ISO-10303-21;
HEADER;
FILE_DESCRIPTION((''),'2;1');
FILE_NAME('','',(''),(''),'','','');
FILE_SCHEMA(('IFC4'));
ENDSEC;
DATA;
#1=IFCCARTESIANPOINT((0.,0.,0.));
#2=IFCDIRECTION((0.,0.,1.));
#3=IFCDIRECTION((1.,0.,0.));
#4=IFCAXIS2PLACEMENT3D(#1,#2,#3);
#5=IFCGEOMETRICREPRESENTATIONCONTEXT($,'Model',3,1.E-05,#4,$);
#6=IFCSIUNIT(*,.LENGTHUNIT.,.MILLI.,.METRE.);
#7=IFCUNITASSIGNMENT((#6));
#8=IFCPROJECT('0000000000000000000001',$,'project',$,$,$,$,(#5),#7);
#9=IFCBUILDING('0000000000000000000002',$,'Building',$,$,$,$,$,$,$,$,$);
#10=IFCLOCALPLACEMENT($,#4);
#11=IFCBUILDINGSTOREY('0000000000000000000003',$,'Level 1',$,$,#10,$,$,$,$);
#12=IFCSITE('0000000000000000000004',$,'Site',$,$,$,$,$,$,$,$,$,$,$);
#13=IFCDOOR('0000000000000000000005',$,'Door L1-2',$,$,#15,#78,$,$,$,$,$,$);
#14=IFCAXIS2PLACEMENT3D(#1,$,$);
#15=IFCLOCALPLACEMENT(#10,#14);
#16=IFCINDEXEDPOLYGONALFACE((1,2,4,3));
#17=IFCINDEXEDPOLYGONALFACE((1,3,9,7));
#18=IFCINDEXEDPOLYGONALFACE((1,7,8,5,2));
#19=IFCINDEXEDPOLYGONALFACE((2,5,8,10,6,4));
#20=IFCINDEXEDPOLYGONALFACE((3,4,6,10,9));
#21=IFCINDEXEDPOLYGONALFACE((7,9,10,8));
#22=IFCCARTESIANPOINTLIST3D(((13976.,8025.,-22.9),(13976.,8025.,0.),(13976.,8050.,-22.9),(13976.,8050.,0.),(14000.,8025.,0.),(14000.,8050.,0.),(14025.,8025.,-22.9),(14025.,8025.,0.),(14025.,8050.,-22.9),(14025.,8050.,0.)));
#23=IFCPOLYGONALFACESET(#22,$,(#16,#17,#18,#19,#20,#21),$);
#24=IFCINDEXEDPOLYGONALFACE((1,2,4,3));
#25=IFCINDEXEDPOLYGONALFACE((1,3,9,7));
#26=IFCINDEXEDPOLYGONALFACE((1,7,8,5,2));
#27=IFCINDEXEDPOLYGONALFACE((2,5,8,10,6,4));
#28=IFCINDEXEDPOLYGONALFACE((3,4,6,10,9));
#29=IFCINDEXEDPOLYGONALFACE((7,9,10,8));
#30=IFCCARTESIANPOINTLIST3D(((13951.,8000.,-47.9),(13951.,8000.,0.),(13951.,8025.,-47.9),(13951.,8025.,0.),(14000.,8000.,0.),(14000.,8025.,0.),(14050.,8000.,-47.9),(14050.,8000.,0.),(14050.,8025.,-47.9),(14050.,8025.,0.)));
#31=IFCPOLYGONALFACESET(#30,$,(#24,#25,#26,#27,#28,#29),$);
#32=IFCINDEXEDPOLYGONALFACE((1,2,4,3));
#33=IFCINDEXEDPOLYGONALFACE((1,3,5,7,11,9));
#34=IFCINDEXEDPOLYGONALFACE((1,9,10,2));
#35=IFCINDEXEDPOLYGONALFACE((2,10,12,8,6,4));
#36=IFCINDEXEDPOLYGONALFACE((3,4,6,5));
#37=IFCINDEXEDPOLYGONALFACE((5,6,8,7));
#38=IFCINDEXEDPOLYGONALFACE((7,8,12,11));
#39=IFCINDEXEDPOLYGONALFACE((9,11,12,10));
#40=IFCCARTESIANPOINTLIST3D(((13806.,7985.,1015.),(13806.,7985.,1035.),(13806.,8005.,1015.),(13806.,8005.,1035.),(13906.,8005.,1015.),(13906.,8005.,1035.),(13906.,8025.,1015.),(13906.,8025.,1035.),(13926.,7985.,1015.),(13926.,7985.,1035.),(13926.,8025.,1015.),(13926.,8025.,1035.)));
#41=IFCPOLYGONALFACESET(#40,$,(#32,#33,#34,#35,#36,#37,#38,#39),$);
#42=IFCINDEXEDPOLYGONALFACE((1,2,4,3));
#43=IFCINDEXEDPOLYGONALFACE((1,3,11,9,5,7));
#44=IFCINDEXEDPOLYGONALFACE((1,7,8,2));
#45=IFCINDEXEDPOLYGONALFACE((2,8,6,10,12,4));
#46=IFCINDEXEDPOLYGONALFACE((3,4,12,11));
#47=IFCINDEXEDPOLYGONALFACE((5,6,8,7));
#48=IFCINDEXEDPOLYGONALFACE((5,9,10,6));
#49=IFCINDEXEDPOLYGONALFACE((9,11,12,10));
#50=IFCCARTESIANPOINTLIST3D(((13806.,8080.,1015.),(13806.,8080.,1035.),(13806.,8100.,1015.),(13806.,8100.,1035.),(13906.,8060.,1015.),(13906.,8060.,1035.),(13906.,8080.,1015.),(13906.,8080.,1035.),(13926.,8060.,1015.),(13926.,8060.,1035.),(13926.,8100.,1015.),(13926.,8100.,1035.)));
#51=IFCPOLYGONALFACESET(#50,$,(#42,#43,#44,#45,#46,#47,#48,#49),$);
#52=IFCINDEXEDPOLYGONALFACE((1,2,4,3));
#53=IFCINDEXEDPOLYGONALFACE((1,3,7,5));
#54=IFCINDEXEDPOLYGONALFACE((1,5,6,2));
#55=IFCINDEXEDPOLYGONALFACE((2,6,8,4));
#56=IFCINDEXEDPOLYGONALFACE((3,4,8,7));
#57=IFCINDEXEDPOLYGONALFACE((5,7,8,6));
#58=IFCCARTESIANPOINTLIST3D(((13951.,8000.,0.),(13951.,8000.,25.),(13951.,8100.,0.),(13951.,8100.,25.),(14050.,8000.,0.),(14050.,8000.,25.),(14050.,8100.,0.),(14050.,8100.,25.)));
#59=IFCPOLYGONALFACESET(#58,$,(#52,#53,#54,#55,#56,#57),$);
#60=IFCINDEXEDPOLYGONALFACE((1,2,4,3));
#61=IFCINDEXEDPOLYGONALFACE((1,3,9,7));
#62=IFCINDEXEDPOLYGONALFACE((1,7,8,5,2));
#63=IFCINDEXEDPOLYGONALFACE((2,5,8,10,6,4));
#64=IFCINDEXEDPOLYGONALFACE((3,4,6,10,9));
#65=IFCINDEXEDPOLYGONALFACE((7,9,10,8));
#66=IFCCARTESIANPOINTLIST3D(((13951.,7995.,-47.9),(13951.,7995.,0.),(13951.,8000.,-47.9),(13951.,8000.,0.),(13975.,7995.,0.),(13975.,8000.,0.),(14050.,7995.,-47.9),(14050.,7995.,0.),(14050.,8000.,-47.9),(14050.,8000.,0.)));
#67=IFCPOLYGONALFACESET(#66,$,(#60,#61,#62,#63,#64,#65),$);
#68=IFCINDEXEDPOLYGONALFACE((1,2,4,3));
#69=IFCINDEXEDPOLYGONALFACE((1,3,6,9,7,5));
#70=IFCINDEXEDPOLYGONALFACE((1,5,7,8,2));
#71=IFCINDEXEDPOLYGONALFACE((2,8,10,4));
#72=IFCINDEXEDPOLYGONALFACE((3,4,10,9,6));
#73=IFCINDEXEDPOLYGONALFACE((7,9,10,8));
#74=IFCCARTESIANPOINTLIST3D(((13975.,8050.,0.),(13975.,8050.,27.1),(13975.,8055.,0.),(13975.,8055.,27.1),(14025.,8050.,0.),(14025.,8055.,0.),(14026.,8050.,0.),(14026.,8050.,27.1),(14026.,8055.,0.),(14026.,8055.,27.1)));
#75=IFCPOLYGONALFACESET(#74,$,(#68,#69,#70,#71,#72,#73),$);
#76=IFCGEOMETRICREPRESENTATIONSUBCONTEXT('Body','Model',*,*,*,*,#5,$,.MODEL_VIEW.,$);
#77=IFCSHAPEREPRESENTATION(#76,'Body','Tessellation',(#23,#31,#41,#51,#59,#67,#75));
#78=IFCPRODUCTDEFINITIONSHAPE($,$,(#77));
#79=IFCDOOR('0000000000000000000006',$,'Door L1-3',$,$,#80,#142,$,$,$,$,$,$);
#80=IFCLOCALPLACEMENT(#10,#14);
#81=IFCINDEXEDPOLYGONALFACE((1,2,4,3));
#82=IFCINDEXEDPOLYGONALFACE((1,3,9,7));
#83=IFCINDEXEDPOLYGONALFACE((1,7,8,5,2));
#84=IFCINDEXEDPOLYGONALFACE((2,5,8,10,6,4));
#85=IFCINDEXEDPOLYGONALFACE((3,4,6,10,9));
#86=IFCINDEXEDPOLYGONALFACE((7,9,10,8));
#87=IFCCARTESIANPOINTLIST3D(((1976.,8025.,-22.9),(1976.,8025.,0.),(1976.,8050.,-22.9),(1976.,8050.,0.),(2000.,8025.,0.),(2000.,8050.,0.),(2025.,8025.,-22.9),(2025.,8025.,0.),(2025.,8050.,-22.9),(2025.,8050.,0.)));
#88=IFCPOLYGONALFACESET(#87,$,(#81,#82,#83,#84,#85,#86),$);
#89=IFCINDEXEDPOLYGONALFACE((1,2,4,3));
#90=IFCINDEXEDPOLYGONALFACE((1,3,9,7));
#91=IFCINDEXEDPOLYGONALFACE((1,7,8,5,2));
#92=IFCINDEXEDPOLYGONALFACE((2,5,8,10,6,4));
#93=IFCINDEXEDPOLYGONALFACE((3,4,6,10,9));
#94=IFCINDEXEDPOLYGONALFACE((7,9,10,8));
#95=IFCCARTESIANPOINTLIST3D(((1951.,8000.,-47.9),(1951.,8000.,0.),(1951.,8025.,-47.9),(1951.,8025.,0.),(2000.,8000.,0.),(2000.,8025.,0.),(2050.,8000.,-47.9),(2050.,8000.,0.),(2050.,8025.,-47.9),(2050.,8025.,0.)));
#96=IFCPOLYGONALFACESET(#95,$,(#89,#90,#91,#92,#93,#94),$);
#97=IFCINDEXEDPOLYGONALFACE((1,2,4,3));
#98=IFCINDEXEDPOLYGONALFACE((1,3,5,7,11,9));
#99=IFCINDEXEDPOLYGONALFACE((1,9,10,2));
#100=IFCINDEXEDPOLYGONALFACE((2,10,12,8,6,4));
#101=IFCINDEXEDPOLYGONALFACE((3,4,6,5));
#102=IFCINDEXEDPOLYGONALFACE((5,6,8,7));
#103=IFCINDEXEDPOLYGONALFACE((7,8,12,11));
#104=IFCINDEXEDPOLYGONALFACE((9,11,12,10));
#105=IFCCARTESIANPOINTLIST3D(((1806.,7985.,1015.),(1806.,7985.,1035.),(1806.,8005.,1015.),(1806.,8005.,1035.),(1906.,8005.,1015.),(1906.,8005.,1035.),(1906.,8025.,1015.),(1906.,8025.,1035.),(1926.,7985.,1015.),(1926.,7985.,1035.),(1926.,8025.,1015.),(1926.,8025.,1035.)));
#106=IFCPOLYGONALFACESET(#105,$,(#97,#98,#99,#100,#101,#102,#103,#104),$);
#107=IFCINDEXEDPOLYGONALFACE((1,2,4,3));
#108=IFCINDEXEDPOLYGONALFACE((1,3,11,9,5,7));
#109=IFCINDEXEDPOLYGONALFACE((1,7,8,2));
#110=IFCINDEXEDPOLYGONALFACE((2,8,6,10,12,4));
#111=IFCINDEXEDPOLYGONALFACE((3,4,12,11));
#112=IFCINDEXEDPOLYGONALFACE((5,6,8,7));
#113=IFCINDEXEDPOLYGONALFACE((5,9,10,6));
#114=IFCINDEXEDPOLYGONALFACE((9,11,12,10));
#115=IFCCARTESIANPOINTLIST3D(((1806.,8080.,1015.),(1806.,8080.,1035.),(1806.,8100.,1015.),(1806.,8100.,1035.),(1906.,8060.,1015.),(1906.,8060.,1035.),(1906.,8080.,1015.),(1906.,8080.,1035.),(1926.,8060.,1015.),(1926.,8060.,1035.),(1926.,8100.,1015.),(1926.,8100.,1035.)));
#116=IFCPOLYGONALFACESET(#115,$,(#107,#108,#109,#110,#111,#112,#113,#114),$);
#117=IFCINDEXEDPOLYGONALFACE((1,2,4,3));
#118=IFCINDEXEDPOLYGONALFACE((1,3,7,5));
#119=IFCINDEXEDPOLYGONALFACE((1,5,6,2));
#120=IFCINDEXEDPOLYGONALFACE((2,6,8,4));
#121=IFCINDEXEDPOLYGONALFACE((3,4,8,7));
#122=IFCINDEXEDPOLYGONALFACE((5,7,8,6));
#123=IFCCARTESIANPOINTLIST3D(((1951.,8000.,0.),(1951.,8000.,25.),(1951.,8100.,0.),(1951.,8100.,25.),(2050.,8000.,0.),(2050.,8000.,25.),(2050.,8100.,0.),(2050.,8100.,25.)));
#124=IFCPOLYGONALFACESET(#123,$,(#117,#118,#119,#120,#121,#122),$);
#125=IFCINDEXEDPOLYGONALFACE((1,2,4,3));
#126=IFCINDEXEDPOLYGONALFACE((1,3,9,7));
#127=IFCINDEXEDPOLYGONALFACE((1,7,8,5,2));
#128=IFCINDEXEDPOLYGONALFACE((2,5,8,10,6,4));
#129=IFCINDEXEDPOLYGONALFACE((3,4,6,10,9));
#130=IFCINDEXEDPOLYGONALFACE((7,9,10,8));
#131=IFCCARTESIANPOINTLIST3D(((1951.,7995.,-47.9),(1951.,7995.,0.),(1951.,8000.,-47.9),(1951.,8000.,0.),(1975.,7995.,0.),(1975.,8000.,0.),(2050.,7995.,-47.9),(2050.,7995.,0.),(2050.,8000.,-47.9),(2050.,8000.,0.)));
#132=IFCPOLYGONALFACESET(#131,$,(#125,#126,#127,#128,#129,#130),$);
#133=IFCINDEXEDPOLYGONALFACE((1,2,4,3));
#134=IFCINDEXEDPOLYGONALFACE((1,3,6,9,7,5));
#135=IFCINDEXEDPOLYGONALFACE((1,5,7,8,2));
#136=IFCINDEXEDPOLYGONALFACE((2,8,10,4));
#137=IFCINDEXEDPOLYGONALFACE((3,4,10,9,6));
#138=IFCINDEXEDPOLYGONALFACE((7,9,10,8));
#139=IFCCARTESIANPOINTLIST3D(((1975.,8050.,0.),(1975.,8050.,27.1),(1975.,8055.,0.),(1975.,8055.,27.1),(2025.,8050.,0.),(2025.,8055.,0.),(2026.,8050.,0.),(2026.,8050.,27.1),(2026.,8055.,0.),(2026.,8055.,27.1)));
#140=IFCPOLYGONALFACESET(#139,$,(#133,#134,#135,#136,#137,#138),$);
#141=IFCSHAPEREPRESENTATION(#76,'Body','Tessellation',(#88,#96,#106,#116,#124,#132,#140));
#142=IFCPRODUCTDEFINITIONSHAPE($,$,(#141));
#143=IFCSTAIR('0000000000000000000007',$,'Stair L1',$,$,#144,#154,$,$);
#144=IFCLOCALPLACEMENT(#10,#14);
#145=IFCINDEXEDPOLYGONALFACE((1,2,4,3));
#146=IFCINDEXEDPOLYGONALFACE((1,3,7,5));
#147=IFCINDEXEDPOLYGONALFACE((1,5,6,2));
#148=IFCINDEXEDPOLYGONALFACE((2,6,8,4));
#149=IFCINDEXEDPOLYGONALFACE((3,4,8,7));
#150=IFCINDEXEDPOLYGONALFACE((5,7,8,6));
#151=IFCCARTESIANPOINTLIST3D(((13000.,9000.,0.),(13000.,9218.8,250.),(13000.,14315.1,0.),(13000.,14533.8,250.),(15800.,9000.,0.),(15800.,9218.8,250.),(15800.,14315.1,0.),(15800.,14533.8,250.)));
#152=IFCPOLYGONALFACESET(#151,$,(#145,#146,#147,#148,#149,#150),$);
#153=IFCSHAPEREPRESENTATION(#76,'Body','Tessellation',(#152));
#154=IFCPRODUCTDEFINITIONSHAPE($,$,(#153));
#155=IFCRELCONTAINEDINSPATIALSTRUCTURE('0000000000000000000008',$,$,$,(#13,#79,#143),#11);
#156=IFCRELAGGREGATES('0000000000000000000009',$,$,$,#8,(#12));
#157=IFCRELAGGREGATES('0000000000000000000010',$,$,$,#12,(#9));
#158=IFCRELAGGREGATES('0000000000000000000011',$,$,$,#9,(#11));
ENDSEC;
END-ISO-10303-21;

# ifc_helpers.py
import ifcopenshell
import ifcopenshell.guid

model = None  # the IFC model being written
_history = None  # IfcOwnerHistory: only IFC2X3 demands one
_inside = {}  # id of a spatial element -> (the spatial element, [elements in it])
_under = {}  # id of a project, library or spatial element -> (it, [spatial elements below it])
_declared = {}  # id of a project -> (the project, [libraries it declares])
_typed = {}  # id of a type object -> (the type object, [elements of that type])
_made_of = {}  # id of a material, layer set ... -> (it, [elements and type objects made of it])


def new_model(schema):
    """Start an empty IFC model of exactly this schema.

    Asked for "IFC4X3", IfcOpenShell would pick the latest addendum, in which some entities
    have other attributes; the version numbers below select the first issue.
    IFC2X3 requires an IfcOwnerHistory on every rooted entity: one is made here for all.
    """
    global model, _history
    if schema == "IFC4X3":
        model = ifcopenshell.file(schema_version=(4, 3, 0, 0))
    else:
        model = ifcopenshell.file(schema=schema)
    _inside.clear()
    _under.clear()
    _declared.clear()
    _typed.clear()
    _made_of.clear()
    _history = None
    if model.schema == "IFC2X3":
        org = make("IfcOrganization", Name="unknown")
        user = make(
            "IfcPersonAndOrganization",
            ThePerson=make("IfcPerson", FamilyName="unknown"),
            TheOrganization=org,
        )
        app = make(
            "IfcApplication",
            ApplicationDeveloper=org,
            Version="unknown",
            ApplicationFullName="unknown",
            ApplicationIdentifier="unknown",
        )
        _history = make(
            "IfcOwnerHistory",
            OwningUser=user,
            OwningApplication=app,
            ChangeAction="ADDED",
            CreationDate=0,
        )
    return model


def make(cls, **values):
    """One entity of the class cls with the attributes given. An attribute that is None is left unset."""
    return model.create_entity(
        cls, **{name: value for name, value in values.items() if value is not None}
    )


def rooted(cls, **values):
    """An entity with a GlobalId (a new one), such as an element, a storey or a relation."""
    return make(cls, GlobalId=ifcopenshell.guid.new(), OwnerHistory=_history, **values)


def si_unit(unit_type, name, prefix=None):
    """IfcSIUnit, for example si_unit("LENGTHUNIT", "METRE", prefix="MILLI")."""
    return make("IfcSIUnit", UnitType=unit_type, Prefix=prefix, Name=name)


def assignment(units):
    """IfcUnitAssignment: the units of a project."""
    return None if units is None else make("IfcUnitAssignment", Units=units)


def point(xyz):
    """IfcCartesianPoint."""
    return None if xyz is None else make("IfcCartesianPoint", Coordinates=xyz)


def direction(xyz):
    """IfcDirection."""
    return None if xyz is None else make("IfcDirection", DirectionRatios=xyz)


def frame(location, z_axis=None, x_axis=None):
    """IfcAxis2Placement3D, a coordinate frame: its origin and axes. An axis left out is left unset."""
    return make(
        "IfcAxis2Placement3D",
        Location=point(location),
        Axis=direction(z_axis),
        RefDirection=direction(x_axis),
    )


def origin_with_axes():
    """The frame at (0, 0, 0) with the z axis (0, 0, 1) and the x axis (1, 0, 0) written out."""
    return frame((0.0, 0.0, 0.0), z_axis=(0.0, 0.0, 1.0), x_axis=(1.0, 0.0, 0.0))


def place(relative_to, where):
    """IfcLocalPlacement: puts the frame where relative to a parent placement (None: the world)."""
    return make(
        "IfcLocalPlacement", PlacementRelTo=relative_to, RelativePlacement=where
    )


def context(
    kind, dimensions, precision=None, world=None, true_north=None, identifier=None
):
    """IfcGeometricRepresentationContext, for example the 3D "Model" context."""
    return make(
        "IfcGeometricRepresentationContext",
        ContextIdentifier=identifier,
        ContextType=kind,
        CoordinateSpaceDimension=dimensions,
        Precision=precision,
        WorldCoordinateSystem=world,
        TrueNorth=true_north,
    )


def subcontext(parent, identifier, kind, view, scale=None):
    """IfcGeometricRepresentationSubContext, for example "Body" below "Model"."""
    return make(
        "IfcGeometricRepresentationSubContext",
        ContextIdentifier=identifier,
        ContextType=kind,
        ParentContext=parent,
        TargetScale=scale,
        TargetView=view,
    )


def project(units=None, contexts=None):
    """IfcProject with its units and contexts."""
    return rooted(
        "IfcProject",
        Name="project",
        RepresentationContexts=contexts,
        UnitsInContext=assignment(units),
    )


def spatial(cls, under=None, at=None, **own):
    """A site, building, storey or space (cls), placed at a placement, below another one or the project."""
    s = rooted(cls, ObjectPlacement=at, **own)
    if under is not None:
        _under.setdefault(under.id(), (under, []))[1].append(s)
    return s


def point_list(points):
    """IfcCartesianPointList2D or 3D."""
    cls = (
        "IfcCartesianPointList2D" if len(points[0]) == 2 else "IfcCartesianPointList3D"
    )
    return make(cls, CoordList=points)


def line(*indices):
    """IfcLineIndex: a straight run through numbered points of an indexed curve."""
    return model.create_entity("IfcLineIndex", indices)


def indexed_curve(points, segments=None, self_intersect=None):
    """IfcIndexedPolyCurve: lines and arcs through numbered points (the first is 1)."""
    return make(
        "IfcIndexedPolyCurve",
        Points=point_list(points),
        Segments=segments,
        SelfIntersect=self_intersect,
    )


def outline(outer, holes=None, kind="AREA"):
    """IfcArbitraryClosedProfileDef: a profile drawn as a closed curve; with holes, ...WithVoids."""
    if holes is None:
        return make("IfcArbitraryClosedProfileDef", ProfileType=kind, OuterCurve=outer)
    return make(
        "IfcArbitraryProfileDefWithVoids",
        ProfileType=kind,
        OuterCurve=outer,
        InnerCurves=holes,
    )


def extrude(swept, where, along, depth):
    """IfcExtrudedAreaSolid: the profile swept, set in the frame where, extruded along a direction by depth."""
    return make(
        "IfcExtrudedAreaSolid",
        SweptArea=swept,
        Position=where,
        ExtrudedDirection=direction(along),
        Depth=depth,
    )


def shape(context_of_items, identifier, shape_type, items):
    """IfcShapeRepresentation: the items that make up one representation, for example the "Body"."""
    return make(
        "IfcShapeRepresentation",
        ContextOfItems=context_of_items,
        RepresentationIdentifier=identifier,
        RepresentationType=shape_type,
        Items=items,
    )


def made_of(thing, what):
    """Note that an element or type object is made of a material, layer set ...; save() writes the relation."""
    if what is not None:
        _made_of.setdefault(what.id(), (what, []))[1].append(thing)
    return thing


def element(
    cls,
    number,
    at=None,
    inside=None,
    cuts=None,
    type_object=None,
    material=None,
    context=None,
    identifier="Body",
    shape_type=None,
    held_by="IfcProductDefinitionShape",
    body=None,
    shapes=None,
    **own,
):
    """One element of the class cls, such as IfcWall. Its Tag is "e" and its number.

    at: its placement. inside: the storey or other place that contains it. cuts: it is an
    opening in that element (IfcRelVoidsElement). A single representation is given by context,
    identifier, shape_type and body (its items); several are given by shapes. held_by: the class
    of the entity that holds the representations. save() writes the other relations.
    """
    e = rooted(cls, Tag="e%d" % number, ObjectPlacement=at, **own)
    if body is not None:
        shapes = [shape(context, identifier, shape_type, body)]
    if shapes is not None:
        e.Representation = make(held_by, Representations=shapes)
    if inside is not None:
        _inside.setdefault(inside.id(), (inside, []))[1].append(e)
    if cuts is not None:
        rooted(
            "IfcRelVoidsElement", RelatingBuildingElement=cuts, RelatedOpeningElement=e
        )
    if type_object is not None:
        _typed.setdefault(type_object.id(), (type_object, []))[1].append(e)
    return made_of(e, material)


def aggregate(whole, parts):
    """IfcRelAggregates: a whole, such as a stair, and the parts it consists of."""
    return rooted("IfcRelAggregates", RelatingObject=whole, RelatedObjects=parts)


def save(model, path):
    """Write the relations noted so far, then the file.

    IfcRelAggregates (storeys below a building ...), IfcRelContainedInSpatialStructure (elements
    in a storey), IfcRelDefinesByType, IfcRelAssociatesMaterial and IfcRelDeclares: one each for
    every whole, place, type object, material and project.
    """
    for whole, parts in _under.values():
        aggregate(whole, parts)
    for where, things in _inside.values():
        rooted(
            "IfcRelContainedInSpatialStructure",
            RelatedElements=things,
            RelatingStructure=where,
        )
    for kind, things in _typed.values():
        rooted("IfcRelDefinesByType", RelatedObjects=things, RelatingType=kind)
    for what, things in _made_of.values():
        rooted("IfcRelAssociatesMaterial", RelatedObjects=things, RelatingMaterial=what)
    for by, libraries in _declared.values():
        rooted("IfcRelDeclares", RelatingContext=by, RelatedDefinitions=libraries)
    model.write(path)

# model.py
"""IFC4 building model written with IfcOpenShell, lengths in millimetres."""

from ifc_helpers import new_model, si_unit, frame, origin_with_axes, place, context, subcontext, project, spatial, line, indexed_curve, outline, extrude, element, save


model = new_model("IFC4")

# Units and contexts
model_context = context("Model", 3, precision=1e-05, world=origin_with_axes())
body_context = subcontext(model_context, "Body", "Model", "MODEL_VIEW")
ifc_project = project(units=[si_unit("LENGTHUNIT", "METRE", prefix="MILLI")], contexts=[model_context])

# Site, building, storey
site = spatial("IfcSite", under=ifc_project, Name="Site")
building = spatial("IfcBuilding", under=site, Name="Building")
storey_placement = place(None, origin_with_axes())
storey = spatial("IfcBuildingStorey", under=building, at=storey_placement, Name="Level 1")

# Doors
door_1_placement = place(storey_placement, frame((14000.0, 8000.0, 0.0), z_axis=(0.0, 0.0, 1.0), x_axis=(1.0, 0.0, 0.0)))
element("IfcDoor", 1, at=door_1_placement, inside=storey, Name="Door L1-2", context=body_context, shape_type="SweptSolid", body=[
    extrude(outline(indexed_curve([(0.0, 0.0), (0.0, 2.1), (1.0, 2.1), (1.0, 0.0), (-24.0, 0.0), (-24.0, -22.9), (25.0, -22.9), (25.0, 0.0)], segments=[line(1, 2, 3, 4, 5, 6, 7, 8, 1)])), frame((0.0, 25.0, 0.0), z_axis=(0.0, -1.0, 0.0), x_axis=(1.0, 0.0, 0.0)), (0.0, 0.0, -1.0), 25.0),
    extrude(outline(indexed_curve([(0.0, 0.0), (0.0, 2.1), (1.0, 2.1), (1.0, 0.0), (-49.0, 0.0), (-49.0, -47.9), (50.0, -47.9), (50.0, 0.0)], segments=[line(1, 2, 3, 4, 5, 6, 7, 8, 1)])), frame((0.0, 0.0, 0.0), z_axis=(0.0, -1.0, 0.0), x_axis=(1.0, 0.0, 0.0)), (0.0, 0.0, -1.0), 25.0),
    extrude(outline(indexed_curve([(0.0, 0.0), (-49.0, 0.0), (-49.0, 35.0), (0.0, 35.0)], segments=[line(1, 2, 3, 4, 1)])), frame((25.0, 25.0, 25.0), z_axis=(0.0, 0.0, 1.0), x_axis=(1.0, 0.0, 0.0)), (0.0, 0.0, 1.0), -47.9),
    extrude(outline(indexed_curve([(0.0, 0.0), (0.0, -40.0), (-120.0, -40.0), (-120.0, -20.0), (-20.0, -20.0), (-20.0, 0.0)], segments=[line(1, 2, 3, 4, 5, 6, 1)])), frame((-74.0, 25.0, 1015.0), z_axis=(0.0, 0.0, 1.0), x_axis=(1.0, 0.0, 0.0)), (0.0, 0.0, 1.0), 20.0),
    extrude(outline(indexed_curve([(0.0, 0.0), (0.0, 40.0), (-120.0, 40.0), (-120.0, 20.0), (-20.0, 20.0), (-20.0, 0.0)], segments=[line(1, 2, 3, 4, 5, 6, 1)])), frame((-74.0, 60.0, 1015.0), z_axis=(0.0, 0.0, 1.0), x_axis=(1.0, 0.0, 0.0)), (0.0, 0.0, 1.0), 20.0),
    extrude(outline(indexed_curve([(0.0, 0.0), (-99.0, 0.0), (-99.0, 100.0), (0.0, 100.0)], segments=[line(1, 2, 3, 4, 1)])), frame((50.0, 0.0, 0.0), z_axis=(0.0, 0.0, 1.0), x_axis=(1.0, 0.0, 0.0)), (0.0, 0.0, 1.0), 25.0),
    extrude(outline(indexed_curve([(0.0, 0.0), (0.0, 27.1), (51.0, 27.1), (51.0, 0.0), (-24.0, 0.0), (-24.0, -47.9), (75.0, -47.9), (75.0, 0.0)], segments=[line(1, 2, 3, 4, 5, 6, 7, 8, 1)])), frame((-25.0, -5.0, 0.0), z_axis=(0.0, -1.0, 0.0), x_axis=(1.0, 0.0, 0.0)), (0.0, 0.0, -1.0), 5.0),
    extrude(outline(indexed_curve([(0.0, 0.0), (0.0, 27.1), (51.0, 27.1), (51.0, 0.0), (1.0, 0.0), (1.0, -22.9), (50.0, -22.9), (50.0, 0.0)], segments=[line(1, 2, 3, 4, 5, 6, 7, 8, 1)])), frame((-25.0, 50.0, 0.0), z_axis=(0.0, -1.0, 0.0), x_axis=(1.0, 0.0, 0.0)), (0.0, 0.0, -1.0), 5.0),
])
door_2_placement = place(storey_placement, frame((2000.0, 8000.0, 0.0), z_axis=(0.0, 0.0, 1.0), x_axis=(1.0, 0.0, 0.0)))
element("IfcDoor", 2, at=door_2_placement, inside=storey, Name="Door L1-3", context=body_context, shape_type="SweptSolid", body=[
    extrude(outline(indexed_curve([(0.0, 0.0), (0.0, 2.1), (1.0, 2.1), (1.0, 0.0), (-24.0, 0.0), (-24.0, -22.9), (25.0, -22.9), (25.0, 0.0)], segments=[line(1, 2, 3, 4, 5, 6, 7, 8, 1)])), frame((0.0, 25.0, 0.0), z_axis=(0.0, -1.0, 0.0), x_axis=(1.0, 0.0, 0.0)), (0.0, 0.0, -1.0), 25.0),
    extrude(outline(indexed_curve([(0.0, 0.0), (0.0, 2.1), (1.0, 2.1), (1.0, 0.0), (-49.0, 0.0), (-49.0, -47.9), (50.0, -47.9), (50.0, 0.0)], segments=[line(1, 2, 3, 4, 5, 6, 7, 8, 1)])), frame((0.0, 0.0, 0.0), z_axis=(0.0, -1.0, 0.0), x_axis=(1.0, 0.0, 0.0)), (0.0, 0.0, -1.0), 25.0),
    extrude(outline(indexed_curve([(0.0, 0.0), (-49.0, 0.0), (-49.0, 35.0), (0.0, 35.0)], segments=[line(1, 2, 3, 4, 1)])), frame((25.0, 25.0, 25.0), z_axis=(0.0, 0.0, 1.0), x_axis=(1.0, 0.0, 0.0)), (0.0, 0.0, 1.0), -47.9),
    extrude(outline(indexed_curve([(0.0, 0.0), (0.0, -40.0), (-120.0, -40.0), (-120.0, -20.0), (-20.0, -20.0), (-20.0, 0.0)], segments=[line(1, 2, 3, 4, 5, 6, 1)])), frame((-74.0, 25.0, 1015.0), z_axis=(0.0, 0.0, 1.0), x_axis=(1.0, 0.0, 0.0)), (0.0, 0.0, 1.0), 20.0),
    extrude(outline(indexed_curve([(0.0, 0.0), (0.0, 40.0), (-120.0, 40.0), (-120.0, 20.0), (-20.0, 20.0), (-20.0, 0.0)], segments=[line(1, 2, 3, 4, 5, 6, 1)])), frame((-74.0, 60.0, 1015.0), z_axis=(0.0, 0.0, 1.0), x_axis=(1.0, 0.0, 0.0)), (0.0, 0.0, 1.0), 20.0),
    extrude(outline(indexed_curve([(0.0, 0.0), (-99.0, 0.0), (-99.0, 100.0), (0.0, 100.0)], segments=[line(1, 2, 3, 4, 1)])), frame((50.0, 0.0, 0.0), z_axis=(0.0, 0.0, 1.0), x_axis=(1.0, 0.0, 0.0)), (0.0, 0.0, 1.0), 25.0),
    extrude(outline(indexed_curve([(0.0, 0.0), (0.0, 27.1), (51.0, 27.1), (51.0, 0.0), (-24.0, 0.0), (-24.0, -47.9), (75.0, -47.9), (75.0, 0.0)], segments=[line(1, 2, 3, 4, 5, 6, 7, 8, 1)])), frame((-25.0, -5.0, 0.0), z_axis=(0.0, -1.0, 0.0), x_axis=(1.0, 0.0, 0.0)), (0.0, 0.0, -1.0), 5.0),
    extrude(outline(indexed_curve([(0.0, 0.0), (0.0, 27.1), (51.0, 27.1), (51.0, 0.0), (1.0, 0.0), (1.0, -22.9), (50.0, -22.9), (50.0, 0.0)], segments=[line(1, 2, 3, 4, 5, 6, 7, 8, 1)])), frame((-25.0, 50.0, 0.0), z_axis=(0.0, -1.0, 0.0), x_axis=(1.0, 0.0, 0.0)), (0.0, 0.0, -1.0), 5.0),
])

# Stair
stair_placement = place(storey_placement, frame((13000.0, 9000.0, 0.0), z_axis=(0.0, 0.0, 1.0), x_axis=(1.0, 0.0, 0.0)))
element("IfcStair", 3, at=stair_placement, inside=storey, Name="Stair L1", context=body_context, shape_type="SweptSolid", body=[
    extrude(outline(indexed_curve([(0.0, 0.0), (2800.0, 0.0), (2800.0, 5315.1), (0.0, 5315.1), (0.0, 0.0)])), None, (0.0, 0.658505, 0.752577), 332.2),
])

save(model, "model.ifc")
